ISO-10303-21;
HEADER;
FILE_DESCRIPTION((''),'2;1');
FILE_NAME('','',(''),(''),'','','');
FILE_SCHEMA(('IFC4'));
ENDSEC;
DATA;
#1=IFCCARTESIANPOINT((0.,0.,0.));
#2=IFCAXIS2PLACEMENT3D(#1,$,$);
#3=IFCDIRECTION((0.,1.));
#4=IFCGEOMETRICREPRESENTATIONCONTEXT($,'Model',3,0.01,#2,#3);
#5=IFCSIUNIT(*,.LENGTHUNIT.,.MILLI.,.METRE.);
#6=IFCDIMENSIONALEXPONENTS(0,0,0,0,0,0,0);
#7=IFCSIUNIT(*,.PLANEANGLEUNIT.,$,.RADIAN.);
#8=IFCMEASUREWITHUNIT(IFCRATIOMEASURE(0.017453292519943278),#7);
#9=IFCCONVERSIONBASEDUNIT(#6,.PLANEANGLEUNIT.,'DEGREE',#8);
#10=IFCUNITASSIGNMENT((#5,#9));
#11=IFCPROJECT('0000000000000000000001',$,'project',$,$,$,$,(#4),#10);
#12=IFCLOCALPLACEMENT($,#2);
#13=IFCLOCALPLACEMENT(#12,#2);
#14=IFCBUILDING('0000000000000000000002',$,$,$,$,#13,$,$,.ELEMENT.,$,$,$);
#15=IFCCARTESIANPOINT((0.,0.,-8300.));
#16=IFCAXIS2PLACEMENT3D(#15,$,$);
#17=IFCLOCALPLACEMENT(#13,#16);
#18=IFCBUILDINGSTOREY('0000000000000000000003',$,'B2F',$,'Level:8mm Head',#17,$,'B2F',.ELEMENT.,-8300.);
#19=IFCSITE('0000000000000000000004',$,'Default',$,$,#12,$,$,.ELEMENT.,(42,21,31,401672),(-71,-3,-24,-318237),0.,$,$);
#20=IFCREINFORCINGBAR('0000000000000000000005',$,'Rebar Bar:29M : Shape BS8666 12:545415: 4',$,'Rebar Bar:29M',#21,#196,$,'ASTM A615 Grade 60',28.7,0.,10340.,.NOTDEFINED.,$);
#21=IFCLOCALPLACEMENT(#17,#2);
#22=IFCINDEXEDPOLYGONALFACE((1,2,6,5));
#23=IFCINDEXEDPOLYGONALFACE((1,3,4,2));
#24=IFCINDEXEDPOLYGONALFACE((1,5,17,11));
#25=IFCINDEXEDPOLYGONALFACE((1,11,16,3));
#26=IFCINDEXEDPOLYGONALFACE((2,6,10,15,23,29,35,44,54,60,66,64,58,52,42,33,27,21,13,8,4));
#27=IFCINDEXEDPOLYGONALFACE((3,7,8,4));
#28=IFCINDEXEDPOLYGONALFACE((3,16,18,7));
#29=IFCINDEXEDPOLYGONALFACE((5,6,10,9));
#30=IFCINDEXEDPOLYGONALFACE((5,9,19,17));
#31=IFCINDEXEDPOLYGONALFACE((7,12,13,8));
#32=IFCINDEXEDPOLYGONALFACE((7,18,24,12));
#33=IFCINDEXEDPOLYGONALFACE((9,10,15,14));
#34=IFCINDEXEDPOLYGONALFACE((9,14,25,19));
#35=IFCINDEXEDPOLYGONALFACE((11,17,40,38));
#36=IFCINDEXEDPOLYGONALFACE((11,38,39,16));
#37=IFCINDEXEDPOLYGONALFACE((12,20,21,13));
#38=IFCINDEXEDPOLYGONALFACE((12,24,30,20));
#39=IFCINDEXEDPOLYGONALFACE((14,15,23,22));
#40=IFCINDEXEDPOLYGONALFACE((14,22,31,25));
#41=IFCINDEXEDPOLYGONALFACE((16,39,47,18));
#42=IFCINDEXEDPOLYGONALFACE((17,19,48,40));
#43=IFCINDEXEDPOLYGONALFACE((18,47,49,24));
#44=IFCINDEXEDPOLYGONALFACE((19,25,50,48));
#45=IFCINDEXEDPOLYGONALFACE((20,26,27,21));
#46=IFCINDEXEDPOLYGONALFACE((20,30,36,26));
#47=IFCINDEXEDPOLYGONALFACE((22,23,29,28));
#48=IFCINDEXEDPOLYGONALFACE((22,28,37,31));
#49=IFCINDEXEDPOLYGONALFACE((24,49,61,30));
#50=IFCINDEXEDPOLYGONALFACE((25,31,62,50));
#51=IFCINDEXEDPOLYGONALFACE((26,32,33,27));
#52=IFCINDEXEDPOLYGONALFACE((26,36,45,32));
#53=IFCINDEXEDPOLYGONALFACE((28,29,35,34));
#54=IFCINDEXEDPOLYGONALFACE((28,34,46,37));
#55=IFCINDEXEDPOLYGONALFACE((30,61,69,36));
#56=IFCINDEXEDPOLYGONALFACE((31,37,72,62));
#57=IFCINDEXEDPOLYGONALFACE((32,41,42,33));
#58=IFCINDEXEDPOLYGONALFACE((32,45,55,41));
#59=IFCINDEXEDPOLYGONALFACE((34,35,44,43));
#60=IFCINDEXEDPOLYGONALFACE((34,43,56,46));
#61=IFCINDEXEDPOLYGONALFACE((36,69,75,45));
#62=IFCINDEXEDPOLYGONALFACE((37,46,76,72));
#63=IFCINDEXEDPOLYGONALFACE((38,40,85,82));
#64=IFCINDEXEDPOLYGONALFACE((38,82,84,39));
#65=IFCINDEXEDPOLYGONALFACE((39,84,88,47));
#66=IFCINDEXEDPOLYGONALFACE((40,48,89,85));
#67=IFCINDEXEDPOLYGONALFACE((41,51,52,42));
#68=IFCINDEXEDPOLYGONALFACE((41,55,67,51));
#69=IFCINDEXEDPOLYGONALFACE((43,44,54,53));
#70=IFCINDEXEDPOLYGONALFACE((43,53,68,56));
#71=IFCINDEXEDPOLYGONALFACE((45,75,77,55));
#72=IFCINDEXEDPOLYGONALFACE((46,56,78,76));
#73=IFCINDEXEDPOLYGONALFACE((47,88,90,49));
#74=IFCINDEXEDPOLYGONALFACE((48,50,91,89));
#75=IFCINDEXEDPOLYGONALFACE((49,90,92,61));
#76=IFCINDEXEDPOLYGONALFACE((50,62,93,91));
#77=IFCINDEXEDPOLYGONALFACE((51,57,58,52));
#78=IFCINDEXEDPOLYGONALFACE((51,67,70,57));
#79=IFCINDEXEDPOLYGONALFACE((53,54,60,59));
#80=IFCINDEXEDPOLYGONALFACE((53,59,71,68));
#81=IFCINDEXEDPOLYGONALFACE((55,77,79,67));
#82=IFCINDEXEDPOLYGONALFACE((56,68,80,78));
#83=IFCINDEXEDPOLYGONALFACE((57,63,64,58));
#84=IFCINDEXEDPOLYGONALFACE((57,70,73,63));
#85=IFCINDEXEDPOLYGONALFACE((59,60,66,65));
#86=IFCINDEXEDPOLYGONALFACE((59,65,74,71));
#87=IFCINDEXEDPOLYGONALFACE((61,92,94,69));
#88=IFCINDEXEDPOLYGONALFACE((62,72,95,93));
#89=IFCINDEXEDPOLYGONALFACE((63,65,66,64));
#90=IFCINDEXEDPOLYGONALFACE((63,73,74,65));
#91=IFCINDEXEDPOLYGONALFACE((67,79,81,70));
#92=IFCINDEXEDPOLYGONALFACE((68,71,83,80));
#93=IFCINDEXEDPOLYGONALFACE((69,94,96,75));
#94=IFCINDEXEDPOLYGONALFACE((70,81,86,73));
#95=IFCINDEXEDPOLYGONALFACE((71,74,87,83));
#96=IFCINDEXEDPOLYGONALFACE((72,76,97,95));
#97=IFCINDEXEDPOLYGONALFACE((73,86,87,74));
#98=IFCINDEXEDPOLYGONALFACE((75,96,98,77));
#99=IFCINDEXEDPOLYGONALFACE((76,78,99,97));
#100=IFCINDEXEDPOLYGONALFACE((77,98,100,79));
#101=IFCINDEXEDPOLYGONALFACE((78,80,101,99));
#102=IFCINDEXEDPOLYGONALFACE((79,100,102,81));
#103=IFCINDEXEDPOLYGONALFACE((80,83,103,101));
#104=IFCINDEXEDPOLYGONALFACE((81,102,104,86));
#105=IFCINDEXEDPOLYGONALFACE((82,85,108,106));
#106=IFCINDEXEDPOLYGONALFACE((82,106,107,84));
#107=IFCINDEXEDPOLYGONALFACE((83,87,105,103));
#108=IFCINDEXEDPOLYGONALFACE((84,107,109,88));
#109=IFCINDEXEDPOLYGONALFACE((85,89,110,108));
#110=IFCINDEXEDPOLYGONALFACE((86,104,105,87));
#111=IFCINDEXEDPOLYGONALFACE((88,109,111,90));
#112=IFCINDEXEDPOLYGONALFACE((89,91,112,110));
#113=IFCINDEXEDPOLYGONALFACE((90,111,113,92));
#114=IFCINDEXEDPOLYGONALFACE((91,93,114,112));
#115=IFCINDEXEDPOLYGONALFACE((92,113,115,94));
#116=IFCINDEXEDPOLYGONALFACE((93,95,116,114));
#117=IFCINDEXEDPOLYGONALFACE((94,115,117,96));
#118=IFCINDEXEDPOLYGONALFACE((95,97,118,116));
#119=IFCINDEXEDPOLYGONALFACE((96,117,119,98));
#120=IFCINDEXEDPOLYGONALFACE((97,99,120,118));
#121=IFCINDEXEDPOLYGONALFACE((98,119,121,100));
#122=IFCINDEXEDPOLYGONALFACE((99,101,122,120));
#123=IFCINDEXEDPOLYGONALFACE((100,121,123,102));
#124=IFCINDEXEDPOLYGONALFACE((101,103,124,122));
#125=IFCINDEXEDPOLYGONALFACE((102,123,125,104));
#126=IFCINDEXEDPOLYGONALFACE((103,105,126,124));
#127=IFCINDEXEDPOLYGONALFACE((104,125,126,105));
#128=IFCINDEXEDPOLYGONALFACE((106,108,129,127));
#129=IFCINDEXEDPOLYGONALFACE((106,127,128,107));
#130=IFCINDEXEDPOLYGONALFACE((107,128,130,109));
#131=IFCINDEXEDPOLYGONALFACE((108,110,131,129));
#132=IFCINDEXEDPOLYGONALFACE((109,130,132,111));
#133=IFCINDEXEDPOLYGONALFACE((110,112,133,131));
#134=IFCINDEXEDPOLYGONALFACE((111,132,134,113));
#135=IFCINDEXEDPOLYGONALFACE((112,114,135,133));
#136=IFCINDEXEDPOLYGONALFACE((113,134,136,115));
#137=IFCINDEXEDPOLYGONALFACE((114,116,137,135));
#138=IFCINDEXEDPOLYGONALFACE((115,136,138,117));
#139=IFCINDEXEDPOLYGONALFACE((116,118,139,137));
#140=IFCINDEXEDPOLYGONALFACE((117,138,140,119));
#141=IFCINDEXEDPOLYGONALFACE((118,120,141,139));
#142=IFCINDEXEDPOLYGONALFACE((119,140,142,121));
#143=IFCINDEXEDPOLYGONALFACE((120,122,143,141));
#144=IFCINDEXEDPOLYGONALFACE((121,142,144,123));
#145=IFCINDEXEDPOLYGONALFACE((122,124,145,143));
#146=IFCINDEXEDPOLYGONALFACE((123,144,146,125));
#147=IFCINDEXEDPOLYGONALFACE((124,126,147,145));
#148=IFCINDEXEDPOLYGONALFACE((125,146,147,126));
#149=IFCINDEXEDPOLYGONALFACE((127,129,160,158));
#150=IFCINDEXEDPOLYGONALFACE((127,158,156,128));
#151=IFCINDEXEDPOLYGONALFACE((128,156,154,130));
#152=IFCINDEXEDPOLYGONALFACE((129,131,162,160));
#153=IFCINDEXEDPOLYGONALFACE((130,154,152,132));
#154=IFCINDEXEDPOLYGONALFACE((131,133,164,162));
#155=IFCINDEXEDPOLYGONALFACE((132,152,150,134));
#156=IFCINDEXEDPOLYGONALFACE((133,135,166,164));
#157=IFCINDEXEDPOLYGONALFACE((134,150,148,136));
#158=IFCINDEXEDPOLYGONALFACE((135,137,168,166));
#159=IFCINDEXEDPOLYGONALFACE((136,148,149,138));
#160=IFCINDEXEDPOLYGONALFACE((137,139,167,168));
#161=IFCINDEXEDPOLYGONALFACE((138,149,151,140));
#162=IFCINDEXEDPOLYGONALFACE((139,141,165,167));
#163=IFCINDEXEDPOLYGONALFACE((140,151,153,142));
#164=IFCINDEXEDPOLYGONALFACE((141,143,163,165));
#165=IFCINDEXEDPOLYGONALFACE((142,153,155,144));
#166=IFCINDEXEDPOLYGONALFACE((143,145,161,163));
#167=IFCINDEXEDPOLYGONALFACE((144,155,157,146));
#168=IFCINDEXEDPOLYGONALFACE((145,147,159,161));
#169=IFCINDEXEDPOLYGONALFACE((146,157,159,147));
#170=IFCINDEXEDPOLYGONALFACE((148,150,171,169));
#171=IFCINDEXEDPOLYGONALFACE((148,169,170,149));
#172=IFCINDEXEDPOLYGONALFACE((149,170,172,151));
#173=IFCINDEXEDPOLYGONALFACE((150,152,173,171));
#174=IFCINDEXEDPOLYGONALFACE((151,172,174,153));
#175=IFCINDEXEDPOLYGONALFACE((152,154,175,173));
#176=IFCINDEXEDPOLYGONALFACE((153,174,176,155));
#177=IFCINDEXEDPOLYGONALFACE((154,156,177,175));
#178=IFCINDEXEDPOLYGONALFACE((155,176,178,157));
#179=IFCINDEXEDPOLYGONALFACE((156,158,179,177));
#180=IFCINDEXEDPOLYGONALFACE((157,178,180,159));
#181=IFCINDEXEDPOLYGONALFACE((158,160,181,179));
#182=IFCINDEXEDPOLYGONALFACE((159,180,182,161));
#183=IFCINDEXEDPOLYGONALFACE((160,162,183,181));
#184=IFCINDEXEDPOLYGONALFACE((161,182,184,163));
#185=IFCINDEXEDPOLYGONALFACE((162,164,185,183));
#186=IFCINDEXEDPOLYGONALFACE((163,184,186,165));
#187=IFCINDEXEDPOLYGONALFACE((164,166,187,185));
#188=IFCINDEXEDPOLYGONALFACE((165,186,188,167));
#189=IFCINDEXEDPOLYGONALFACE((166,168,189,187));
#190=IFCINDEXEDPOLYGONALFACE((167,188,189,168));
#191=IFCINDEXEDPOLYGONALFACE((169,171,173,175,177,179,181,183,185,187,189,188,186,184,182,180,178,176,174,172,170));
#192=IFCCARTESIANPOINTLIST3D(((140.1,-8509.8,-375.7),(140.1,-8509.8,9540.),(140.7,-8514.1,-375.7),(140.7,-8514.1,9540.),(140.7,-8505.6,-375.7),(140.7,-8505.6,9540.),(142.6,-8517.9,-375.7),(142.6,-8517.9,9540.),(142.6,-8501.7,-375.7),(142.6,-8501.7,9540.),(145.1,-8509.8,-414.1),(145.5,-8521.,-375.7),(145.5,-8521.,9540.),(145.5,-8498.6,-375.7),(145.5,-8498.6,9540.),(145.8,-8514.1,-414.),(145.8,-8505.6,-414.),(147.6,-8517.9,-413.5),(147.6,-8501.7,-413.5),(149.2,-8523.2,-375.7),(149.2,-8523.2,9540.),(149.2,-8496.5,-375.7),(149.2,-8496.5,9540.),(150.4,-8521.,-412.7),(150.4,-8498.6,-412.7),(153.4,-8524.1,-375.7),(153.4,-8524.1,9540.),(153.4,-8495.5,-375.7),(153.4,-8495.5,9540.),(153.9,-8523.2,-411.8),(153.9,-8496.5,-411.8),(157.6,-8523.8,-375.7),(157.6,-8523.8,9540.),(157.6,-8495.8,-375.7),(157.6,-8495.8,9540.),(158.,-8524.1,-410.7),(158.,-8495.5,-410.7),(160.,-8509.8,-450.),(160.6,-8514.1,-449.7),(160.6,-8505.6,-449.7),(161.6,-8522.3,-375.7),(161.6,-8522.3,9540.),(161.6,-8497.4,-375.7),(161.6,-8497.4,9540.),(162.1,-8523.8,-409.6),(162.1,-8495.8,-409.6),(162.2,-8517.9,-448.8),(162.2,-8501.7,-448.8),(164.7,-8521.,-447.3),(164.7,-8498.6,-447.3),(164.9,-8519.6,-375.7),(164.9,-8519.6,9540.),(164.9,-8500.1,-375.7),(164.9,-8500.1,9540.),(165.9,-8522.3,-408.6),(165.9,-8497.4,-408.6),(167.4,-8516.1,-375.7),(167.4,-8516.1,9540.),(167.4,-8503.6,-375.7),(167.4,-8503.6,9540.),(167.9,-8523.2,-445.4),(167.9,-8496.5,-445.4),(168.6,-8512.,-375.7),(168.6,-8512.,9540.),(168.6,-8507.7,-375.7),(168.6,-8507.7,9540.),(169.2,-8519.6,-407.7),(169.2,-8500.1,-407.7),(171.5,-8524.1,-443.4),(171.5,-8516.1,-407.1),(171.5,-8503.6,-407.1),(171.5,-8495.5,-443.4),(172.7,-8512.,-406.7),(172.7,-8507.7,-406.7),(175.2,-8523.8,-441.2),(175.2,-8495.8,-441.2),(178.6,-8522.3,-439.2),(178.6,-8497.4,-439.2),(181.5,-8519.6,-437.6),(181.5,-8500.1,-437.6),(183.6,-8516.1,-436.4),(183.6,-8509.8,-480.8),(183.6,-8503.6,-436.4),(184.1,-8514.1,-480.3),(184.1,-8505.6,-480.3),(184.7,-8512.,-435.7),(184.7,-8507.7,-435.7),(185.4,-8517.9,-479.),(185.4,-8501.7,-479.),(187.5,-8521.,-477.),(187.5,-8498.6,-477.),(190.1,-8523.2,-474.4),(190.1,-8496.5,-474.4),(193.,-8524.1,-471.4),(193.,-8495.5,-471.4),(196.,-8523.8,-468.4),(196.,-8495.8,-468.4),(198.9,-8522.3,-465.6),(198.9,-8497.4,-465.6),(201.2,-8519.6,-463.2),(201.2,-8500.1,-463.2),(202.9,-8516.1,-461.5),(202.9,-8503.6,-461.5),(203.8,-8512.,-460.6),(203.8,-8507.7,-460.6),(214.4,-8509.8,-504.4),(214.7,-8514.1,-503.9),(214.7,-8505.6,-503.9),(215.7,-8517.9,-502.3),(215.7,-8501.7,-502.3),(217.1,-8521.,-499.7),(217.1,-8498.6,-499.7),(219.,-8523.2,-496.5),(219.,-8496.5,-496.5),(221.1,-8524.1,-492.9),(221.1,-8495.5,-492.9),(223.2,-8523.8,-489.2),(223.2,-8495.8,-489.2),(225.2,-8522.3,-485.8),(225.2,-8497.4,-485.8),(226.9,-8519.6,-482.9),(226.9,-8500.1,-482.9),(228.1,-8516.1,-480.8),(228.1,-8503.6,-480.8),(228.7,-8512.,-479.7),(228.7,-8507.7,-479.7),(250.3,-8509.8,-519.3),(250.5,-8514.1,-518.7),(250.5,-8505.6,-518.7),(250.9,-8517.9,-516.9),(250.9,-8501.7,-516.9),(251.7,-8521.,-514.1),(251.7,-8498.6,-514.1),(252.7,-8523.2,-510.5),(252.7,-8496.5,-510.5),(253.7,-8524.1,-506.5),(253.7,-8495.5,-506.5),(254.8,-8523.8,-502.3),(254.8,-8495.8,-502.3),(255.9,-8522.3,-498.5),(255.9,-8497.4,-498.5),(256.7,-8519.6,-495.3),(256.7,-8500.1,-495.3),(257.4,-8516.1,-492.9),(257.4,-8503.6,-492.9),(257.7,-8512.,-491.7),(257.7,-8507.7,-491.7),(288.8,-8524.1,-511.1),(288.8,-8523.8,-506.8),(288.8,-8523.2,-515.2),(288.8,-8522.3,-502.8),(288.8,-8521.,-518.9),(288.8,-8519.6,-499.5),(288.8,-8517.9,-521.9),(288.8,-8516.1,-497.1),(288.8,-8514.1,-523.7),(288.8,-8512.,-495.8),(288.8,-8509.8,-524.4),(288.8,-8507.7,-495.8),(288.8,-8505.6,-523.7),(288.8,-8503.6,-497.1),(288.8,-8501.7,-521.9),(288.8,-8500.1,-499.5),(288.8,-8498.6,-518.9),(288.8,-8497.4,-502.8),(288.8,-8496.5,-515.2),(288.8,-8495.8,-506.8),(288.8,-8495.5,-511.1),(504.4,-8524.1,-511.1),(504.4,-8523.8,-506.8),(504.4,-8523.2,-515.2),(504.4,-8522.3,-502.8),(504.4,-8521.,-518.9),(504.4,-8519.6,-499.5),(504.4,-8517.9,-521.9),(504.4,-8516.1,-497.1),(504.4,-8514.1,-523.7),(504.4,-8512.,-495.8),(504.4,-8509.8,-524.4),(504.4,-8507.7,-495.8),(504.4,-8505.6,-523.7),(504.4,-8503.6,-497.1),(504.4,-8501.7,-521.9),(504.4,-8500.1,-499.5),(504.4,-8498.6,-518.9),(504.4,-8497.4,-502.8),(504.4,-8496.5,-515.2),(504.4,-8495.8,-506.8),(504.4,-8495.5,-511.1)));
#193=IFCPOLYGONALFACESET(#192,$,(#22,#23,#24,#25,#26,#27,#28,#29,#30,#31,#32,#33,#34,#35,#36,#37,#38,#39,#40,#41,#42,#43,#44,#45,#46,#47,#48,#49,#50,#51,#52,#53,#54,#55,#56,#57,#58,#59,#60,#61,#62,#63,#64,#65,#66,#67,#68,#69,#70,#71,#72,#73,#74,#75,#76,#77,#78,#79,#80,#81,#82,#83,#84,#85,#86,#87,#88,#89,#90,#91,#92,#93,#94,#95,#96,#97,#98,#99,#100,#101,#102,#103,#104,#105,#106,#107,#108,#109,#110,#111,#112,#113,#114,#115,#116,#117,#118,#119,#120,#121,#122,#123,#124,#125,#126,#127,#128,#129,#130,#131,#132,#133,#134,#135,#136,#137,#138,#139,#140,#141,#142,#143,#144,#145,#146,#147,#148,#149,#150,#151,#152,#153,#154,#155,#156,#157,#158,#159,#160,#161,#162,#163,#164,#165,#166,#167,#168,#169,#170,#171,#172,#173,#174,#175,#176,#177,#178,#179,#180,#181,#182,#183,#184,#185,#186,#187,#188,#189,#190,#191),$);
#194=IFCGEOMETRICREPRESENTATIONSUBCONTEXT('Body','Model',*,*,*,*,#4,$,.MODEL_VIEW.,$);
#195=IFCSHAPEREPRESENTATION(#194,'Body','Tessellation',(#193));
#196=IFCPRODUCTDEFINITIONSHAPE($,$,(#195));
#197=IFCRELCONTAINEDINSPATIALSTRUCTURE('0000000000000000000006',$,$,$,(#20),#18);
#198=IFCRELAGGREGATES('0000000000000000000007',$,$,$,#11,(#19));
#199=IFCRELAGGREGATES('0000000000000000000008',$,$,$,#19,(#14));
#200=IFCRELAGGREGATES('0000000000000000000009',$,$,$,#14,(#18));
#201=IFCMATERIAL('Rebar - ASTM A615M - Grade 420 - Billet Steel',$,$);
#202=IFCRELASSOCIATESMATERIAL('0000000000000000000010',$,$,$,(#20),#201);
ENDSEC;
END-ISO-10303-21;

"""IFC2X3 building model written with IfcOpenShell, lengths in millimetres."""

from ifc_helpers import new_model, entity, si_unit, converted_unit, direction, frame, origin, place, context, subcontext, project, spatial, material, element, save


model = new_model("IFC2X3")

# Units and contexts
model_context = context("Model", 3, precision=0.01, world=origin(), true_north=direction((0.0, 1.0)))
body_context = subcontext(model_context, "Body", "Model", "MODEL_VIEW")
ifc_project = project(units=[si_unit("LENGTHUNIT", "METRE", prefix="MILLI"), converted_unit("PLANEANGLEUNIT", "DEGREE", entity("IfcRatioMeasure", 0.017453292519943278), si_unit("PLANEANGLEUNIT", "RADIAN"), dimensions=[0, 0, 0, 0, 0, 0, 0])], contexts=[model_context])

# Site, building, storey
site_placement = place(None, origin())
site = spatial("IfcSite", under=ifc_project, at=site_placement, Name="Default", CompositionType="ELEMENT", RefLatitude=(42, 21, 31, 401672), RefLongitude=(-71, -3, -24, -318237), RefElevation=0.0)
building_placement = place(site_placement, origin())
building = spatial("IfcBuilding", under=site, at=building_placement, CompositionType="ELEMENT")
storey_placement = place(building_placement, frame((0.0, 0.0, -8300.0)))
storey = spatial("IfcBuildingStorey", under=building, at=storey_placement, Name="B2F", ObjectType="Level:8mm Head", LongName="B2F", CompositionType="ELEMENT", Elevation=-8300.0)

# Reinforcing bar
ifc_material_1 = material(Name="Rebar - ASTM A615M - Grade 420 - Billet Steel")
reinforcing_bar_1_placement = place(storey_placement, origin())
element("IfcReinforcingBar", 1, at=reinforcing_bar_1_placement, inside=storey, material=ifc_material_1, Name="Rebar Bar:29M : Shape BS8666 12:545415: 4", SteelGrade="ASTM A615 Grade 60", ObjectType="Rebar Bar:29M", BarLength=10340.0, BarRole="NOTDEFINED", CrossSectionArea=0.0, NominalDiameter=28.7, context=body_context, shape_type="AdvancedSweptSolid", body=[
    entity("IfcSweptDiskSolid", entity("IfcCompositeCurve", [entity("IfcCompositeCurveSegment", "CONTINUOUS", True, entity("IfcPolyline", [entity("IfcCartesianPoint", [154.4, -8509.8, 9540.0]), entity("IfcCartesianPoint", [154.4, -8509.8, -375.7])])), entity("IfcCompositeCurveSegment", "CONTINUOUS", True, entity("IfcTrimmedCurve", entity("IfcCircle", entity("IfcAxis2Placement3D", entity("IfcCartesianPoint", [288.8, -8509.8, -375.7]), entity("IfcDirection", [0.0, -1.0, 0.0]), entity("IfcDirection", [0.0, 0.0, -1.0])), 134.3), [entity("IfcParameterValue", 270.0)], [entity("IfcParameterValue", 360.0)], True, "PARAMETER")), entity("IfcCompositeCurveSegment", "CONTINUOUS", True, entity("IfcPolyline", [entity("IfcCartesianPoint", [288.8, -8509.8, -510.0]), entity("IfcCartesianPoint", [504.4, -8509.8, -510.0])]))], False), 14.3, None, 0.0, 92.0),
])

save(model, "model.ifc")
